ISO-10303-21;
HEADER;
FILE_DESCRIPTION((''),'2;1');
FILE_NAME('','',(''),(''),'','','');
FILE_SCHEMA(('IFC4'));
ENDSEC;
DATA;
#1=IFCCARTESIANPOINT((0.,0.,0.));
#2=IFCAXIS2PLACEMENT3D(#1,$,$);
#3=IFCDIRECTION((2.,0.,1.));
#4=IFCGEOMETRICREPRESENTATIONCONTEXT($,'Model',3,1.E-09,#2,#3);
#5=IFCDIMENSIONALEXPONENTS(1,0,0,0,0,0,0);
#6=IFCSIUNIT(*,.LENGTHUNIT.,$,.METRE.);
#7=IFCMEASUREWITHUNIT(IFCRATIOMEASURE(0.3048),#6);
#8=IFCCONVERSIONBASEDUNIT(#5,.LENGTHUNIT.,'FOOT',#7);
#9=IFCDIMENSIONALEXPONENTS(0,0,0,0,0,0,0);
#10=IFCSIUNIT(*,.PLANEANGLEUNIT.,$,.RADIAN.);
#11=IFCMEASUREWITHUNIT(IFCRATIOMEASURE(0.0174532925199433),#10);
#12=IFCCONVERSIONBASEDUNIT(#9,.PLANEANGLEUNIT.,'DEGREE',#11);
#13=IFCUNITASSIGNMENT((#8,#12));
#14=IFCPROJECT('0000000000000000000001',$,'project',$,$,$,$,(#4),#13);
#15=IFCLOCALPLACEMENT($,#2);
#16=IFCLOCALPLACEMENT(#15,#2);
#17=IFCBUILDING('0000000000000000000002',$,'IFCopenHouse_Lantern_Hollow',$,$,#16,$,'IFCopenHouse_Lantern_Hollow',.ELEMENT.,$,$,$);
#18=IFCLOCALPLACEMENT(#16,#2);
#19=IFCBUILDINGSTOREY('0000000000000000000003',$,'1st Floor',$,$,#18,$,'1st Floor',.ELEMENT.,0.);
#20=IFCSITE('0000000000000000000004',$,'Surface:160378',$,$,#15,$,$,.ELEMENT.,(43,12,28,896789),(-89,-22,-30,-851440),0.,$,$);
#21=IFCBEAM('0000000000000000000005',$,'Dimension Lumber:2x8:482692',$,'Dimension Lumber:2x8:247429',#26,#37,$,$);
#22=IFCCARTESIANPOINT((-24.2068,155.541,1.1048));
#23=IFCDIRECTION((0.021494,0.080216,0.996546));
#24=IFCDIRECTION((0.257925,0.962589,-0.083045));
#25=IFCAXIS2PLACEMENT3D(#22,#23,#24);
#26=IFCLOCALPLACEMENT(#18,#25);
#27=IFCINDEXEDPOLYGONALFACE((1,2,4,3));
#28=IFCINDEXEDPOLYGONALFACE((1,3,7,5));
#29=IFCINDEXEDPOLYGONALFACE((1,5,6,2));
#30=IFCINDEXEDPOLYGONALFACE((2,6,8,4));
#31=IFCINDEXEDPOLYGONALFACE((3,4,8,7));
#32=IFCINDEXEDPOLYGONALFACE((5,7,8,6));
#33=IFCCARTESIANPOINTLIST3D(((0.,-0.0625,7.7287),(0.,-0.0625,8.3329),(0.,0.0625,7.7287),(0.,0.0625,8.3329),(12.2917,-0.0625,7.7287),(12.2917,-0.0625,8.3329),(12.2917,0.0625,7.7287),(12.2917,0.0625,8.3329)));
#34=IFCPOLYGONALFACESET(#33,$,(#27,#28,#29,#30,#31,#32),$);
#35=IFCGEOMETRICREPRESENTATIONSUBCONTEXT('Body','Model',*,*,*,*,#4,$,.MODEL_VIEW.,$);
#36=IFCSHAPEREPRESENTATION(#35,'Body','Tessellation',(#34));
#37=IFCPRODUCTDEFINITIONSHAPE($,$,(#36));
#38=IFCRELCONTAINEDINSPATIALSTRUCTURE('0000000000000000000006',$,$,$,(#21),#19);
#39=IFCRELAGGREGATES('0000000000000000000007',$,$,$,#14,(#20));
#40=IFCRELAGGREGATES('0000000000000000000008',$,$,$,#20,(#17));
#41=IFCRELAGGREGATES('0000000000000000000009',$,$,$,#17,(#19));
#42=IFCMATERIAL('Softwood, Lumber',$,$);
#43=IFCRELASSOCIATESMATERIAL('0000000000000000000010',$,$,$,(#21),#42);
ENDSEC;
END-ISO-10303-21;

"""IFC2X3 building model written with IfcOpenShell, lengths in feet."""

from ifc_helpers import new_model, entity, si_unit, converted_unit, direction, frame, frame_2d, origin, place, context, subcontext, project, spatial, rectangle, extrude, material, element, save


model = new_model("IFC2X3")

# Units and contexts
model_context = context("Model", 3, precision=1e-09, world=origin(), true_north=direction((2.0, 0.0, 1.0)))
body_context = subcontext(model_context, "Body", "Model", "MODEL_VIEW")
ifc_project = project(units=[converted_unit("LENGTHUNIT", "FOOT", entity("IfcRatioMeasure", 0.3048), si_unit("LENGTHUNIT", "METRE"), dimensions=[1, 0, 0, 0, 0, 0, 0]), converted_unit("PLANEANGLEUNIT", "DEGREE", entity("IfcRatioMeasure", 0.0174532925199433), si_unit("PLANEANGLEUNIT", "RADIAN"), dimensions=[0, 0, 0, 0, 0, 0, 0])], contexts=[model_context])

# Site, building, storey
site_placement = place(None, origin())
site = spatial("IfcSite", under=ifc_project, at=site_placement, Name="Surface:160378", CompositionType="ELEMENT", RefLatitude=(43, 12, 28, 896789), RefLongitude=(-89, -22, -30, -851440), RefElevation=0.0)
building_placement = place(site_placement, origin())
building = spatial("IfcBuilding", under=site, at=building_placement, Name="IFCopenHouse_Lantern_Hollow", LongName="IFCopenHouse_Lantern_Hollow", CompositionType="ELEMENT")
storey_placement = place(building_placement, origin())
storey = spatial("IfcBuildingStorey", under=building, at=storey_placement, Name="1st Floor", LongName="1st Floor", CompositionType="ELEMENT", Elevation=0.0)

# Beam
ifc_material_1 = material(Name="Softwood, Lumber")
beam_1_placement = place(storey_placement, frame((-24.2068, 155.541, 1.1048), z_axis=(0.021494, 0.080216, 0.996546), x_axis=(0.257925, 0.962589, -0.083045)))
element("IfcBeam", 1, at=beam_1_placement, inside=storey, material=ifc_material_1, Name="Dimension Lumber:2x8:482692", ObjectType="Dimension Lumber:2x8:247429", context=body_context, shape_type="SweptSolid", body=[
    extrude(rectangle(XDim=0.6042, YDim=0.125, at=frame_2d((0.0, 0.0), x_axis=(1.0, 0.0))), frame((0.0, 0.0, 8.0308), z_axis=(1.0, 0.0, 0.0), x_axis=(0.0, 0.0, -1.0)), (0.0, 0.0, 1.0), 12.2917),
])

save(model, "model.ifc")
